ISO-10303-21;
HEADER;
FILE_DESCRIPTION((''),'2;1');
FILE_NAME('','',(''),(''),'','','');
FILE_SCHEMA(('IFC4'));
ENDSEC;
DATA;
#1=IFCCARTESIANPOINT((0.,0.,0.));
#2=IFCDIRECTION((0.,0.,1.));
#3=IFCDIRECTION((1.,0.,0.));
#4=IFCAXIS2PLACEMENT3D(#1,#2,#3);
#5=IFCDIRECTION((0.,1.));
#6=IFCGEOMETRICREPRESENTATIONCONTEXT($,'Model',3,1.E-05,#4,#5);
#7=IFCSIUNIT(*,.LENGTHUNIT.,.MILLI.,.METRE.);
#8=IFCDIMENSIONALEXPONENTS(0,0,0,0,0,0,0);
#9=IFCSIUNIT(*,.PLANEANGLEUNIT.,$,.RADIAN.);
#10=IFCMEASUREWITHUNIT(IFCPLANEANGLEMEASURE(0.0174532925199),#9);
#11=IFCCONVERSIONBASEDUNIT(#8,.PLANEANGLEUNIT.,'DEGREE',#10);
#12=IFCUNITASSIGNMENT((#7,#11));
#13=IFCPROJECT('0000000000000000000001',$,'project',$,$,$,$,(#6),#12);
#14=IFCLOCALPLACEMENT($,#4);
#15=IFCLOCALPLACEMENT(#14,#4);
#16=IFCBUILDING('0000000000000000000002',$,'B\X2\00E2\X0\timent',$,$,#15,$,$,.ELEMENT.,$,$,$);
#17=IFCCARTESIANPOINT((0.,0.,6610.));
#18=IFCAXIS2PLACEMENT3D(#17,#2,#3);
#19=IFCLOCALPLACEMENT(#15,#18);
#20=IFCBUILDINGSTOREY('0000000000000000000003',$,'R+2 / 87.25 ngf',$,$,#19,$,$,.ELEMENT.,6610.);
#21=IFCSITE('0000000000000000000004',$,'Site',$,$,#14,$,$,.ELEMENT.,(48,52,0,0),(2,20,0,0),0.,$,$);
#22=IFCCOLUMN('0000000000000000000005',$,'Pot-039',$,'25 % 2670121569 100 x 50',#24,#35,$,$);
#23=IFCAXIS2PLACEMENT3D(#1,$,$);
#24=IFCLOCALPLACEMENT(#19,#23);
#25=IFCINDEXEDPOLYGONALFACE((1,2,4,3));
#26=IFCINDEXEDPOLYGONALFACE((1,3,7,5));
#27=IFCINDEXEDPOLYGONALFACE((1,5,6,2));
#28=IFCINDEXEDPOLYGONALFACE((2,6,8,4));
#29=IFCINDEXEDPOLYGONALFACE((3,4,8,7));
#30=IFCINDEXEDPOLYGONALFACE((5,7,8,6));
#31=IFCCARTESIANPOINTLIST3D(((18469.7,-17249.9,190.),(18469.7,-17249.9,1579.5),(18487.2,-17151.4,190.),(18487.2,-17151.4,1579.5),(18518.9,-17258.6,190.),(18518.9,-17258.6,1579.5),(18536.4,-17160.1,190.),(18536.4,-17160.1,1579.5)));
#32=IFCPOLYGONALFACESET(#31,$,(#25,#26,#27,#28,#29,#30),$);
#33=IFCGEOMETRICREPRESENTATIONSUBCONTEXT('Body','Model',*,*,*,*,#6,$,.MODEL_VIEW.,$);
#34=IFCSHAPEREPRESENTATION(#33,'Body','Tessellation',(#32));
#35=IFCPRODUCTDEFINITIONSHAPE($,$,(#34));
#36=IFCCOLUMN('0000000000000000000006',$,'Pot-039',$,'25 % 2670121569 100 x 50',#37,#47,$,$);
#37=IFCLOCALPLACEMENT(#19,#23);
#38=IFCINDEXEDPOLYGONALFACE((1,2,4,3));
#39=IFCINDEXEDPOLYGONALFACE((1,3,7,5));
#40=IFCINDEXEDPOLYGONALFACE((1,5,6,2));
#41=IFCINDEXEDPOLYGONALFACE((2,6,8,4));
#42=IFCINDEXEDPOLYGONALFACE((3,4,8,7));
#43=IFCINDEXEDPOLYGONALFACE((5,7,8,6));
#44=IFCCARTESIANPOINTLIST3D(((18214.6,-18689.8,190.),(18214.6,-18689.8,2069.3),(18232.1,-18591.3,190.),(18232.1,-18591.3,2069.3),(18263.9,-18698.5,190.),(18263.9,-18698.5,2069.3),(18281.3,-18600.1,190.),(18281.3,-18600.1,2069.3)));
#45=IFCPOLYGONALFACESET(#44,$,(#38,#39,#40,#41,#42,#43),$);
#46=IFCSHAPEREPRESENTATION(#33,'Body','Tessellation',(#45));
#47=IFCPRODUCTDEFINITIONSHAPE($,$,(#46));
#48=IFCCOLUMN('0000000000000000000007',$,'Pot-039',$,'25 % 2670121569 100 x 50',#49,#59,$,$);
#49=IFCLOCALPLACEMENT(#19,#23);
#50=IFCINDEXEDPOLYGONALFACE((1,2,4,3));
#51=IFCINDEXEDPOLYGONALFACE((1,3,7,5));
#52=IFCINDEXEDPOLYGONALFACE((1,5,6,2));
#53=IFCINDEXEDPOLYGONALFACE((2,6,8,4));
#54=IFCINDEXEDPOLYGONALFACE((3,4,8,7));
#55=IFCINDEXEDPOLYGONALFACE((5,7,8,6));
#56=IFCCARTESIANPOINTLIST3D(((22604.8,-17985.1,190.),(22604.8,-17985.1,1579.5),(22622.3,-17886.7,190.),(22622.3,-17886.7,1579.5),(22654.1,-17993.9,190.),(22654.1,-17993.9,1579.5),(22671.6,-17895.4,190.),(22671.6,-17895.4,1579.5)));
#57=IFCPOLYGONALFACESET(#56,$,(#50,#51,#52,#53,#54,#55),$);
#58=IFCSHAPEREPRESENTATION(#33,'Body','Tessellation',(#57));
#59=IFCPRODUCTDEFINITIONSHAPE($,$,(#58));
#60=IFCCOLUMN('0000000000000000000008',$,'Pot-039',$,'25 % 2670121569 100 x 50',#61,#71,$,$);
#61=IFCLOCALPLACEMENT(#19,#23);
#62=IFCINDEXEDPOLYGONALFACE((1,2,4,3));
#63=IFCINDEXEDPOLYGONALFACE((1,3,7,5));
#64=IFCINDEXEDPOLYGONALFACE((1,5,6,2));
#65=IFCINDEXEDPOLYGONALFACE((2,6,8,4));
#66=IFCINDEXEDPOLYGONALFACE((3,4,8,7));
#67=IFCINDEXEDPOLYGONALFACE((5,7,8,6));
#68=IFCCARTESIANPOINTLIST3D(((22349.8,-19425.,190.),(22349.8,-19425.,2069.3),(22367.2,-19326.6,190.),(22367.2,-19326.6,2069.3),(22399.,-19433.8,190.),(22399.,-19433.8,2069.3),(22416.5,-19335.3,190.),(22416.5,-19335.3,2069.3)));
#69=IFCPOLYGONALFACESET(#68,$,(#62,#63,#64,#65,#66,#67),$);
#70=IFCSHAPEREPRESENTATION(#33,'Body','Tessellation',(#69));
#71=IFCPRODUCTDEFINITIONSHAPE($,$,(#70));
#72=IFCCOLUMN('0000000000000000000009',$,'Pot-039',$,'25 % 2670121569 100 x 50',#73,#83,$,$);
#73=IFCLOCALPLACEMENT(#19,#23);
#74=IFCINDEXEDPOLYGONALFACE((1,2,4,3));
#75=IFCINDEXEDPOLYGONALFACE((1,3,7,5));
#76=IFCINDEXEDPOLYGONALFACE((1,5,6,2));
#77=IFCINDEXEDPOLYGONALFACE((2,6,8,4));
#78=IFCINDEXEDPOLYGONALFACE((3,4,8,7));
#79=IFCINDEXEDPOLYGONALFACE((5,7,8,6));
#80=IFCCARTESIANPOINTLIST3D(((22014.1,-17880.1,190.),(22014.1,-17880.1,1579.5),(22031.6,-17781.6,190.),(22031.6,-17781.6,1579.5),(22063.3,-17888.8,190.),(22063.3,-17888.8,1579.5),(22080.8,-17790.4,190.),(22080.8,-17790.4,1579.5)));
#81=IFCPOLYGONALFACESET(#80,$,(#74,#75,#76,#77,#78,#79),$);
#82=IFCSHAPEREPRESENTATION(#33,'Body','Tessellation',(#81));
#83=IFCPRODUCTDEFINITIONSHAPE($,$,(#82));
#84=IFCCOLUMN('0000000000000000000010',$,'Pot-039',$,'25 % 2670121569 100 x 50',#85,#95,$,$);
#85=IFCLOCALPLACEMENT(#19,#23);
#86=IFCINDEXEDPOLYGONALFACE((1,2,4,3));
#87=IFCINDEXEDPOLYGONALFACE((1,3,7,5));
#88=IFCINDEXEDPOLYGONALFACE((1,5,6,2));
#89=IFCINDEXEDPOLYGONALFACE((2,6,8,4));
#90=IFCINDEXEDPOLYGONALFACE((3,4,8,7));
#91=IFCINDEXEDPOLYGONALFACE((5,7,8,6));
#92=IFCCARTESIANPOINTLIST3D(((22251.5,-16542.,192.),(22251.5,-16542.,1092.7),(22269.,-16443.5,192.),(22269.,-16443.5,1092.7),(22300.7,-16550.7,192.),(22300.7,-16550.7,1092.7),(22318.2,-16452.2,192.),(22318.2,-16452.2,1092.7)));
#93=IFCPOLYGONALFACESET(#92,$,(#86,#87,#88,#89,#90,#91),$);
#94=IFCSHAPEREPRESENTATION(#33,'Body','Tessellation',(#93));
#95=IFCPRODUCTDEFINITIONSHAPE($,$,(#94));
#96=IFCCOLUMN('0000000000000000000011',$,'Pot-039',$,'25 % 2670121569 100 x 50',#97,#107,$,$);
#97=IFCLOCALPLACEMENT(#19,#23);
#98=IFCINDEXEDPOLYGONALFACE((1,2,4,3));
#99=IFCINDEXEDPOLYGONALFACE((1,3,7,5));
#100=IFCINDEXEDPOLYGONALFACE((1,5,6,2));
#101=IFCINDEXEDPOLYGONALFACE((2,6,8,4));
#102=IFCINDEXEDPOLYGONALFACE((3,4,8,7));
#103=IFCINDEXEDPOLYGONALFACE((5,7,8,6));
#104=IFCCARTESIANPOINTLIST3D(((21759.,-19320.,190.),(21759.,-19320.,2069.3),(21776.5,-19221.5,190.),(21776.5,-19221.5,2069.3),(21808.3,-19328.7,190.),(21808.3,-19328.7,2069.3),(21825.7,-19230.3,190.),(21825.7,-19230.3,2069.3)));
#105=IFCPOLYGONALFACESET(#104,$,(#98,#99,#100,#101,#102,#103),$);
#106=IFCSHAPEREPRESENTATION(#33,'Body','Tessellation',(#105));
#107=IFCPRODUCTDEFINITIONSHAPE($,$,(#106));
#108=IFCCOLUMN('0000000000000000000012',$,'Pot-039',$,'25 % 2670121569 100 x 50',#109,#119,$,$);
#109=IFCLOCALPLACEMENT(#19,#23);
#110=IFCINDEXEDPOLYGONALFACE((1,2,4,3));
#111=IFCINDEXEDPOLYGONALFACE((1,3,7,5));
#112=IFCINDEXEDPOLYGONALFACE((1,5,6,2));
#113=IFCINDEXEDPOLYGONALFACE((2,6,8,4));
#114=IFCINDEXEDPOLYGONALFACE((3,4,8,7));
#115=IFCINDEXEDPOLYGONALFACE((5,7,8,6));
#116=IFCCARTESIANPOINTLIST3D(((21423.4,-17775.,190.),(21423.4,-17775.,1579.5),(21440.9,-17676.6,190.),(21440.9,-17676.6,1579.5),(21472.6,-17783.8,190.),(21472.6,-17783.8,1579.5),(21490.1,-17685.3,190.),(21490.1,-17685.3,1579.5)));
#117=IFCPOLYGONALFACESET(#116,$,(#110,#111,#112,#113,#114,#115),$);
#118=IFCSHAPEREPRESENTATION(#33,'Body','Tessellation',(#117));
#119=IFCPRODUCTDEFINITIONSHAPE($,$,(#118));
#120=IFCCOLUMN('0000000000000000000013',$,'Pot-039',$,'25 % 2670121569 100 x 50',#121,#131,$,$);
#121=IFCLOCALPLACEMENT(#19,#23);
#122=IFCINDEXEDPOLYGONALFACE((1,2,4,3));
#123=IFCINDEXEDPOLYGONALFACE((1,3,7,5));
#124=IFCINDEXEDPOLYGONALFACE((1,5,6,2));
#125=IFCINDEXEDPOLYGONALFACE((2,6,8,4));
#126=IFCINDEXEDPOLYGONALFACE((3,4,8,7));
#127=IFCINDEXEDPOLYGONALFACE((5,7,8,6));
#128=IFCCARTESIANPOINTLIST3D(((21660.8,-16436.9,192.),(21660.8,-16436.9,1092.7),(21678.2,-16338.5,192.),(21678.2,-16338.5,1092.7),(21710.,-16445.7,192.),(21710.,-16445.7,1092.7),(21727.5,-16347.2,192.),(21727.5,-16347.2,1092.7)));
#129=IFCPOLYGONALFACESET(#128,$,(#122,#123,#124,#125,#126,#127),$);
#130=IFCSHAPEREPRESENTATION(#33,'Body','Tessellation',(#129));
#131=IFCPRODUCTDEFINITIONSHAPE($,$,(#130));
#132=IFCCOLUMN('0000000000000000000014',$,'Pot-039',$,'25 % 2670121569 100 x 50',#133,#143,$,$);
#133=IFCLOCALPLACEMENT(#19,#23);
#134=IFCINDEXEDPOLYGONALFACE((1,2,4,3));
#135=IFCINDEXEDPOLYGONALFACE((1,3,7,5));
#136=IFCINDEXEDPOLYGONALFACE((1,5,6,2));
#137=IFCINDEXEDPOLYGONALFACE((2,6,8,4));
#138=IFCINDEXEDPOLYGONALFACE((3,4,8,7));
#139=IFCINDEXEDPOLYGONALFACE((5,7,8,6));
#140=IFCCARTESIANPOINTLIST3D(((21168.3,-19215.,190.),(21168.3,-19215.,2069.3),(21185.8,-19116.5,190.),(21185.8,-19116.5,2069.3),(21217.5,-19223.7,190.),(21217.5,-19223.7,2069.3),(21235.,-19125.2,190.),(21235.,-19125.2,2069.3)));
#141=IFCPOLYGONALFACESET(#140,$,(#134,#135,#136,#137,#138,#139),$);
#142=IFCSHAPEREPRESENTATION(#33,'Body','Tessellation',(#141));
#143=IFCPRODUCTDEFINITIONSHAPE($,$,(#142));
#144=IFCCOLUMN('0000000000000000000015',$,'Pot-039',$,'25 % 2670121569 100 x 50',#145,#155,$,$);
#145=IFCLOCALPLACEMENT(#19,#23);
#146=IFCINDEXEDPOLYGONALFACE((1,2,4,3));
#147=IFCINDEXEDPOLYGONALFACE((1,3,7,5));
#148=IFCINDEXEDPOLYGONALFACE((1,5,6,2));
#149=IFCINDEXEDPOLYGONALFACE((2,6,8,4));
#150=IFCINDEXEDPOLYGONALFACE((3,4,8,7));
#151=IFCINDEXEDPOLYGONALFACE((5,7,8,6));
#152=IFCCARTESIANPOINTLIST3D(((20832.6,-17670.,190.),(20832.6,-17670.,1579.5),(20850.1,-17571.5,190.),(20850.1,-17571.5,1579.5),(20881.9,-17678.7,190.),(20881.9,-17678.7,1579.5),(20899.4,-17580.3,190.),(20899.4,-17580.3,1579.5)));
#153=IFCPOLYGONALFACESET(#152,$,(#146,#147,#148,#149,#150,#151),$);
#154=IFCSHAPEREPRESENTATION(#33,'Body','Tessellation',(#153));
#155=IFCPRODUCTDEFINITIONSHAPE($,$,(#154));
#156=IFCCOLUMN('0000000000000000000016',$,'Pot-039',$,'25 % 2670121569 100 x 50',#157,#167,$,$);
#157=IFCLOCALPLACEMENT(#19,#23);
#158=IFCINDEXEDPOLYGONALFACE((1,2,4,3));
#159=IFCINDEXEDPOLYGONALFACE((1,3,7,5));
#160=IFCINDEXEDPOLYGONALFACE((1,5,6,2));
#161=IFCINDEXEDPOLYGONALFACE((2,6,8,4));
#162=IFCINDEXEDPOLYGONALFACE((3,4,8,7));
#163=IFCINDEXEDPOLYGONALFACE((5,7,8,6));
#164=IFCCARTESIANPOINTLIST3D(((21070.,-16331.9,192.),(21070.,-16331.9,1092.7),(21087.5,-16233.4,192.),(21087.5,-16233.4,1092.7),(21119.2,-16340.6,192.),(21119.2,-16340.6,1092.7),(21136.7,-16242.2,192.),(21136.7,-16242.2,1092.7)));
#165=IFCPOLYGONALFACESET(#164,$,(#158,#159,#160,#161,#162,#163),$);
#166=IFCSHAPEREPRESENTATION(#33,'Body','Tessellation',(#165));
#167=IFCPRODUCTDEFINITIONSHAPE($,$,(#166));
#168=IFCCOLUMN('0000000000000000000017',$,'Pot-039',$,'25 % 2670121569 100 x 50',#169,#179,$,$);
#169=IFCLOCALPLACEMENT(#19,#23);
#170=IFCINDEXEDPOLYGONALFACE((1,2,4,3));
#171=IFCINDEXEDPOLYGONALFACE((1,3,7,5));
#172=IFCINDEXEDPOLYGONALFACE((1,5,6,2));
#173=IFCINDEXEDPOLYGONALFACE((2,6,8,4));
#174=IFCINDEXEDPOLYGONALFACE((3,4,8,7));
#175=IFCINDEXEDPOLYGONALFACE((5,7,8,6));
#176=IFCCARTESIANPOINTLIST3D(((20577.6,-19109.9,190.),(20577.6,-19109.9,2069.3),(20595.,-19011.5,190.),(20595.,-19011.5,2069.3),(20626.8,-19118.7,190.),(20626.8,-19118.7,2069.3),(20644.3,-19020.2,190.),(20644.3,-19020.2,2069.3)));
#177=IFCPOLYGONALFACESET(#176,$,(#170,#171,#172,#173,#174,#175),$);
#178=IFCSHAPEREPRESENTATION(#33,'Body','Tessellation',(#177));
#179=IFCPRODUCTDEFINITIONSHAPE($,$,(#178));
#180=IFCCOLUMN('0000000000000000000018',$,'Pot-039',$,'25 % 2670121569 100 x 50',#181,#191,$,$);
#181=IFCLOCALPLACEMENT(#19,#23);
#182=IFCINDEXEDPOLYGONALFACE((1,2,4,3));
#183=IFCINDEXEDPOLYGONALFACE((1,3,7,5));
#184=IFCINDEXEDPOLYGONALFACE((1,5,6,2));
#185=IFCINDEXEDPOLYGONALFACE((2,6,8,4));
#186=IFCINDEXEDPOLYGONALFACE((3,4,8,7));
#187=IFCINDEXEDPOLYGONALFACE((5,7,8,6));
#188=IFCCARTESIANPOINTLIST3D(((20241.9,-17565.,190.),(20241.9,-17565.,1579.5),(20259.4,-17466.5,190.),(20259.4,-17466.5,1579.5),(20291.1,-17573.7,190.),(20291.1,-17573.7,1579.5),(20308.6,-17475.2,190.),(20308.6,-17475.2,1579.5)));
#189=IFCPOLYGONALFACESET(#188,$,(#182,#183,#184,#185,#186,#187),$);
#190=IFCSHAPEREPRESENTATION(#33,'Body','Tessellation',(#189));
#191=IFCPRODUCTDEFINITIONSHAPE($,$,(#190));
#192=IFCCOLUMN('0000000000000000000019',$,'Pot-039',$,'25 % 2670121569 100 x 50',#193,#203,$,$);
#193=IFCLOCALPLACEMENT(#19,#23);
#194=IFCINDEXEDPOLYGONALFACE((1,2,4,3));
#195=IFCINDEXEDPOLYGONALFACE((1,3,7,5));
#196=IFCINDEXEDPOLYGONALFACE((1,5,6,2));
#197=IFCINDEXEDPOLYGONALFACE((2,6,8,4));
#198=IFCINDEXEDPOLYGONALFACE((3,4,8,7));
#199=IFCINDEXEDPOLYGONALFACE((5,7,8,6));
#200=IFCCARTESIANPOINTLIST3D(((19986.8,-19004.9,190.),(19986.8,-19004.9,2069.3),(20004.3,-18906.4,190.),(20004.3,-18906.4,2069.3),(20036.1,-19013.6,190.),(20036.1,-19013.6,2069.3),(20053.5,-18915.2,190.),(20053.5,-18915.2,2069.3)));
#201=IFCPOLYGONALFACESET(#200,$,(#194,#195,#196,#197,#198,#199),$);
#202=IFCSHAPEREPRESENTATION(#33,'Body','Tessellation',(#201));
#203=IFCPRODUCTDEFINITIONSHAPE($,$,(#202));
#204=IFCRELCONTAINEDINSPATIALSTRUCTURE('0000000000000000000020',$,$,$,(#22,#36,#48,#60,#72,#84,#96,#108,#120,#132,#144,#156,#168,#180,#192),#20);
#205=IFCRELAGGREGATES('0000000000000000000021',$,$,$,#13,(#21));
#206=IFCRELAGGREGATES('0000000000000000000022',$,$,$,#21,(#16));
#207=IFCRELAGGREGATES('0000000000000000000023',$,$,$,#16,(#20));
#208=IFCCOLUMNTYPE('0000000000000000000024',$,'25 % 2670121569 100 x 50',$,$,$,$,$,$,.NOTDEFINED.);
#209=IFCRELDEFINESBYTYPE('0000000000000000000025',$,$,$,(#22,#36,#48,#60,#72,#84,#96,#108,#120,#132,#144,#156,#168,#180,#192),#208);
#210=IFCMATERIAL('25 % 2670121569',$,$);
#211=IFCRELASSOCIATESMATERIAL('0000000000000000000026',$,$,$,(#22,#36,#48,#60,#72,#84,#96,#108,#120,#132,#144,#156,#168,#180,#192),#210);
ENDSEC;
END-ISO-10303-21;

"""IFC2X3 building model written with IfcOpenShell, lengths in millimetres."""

from ifc_helpers import new_model, entity, si_unit, converted_unit, direction, frame, origin_with_axes, origin_2d_with_axis, place, context, subcontext, project, spatial, rectangle, extrude, material, type_object, element, save


model = new_model("IFC2X3")

# Units and contexts
model_context = context("Model", 3, precision=1e-05, world=origin_with_axes(), true_north=direction((0.0, 1.0)))
body_context = subcontext(model_context, "Body", "Model", "MODEL_VIEW")
ifc_project = project(units=[si_unit("LENGTHUNIT", "METRE", prefix="MILLI"), converted_unit("PLANEANGLEUNIT", "DEGREE", entity("IfcPlaneAngleMeasure", 0.0174532925199), si_unit("PLANEANGLEUNIT", "RADIAN"), dimensions=[0, 0, 0, 0, 0, 0, 0])], contexts=[model_context])

# Site, building, storey
site_placement = place(None, origin_with_axes())
site = spatial("IfcSite", under=ifc_project, at=site_placement, Name="Site", CompositionType="ELEMENT", RefLatitude=(48, 52, 0, 0), RefLongitude=(2, 20, 0, 0), RefElevation=0.0)
building_placement = place(site_placement, origin_with_axes())
building = spatial("IfcBuilding", under=site, at=building_placement, Name="Bâtiment", CompositionType="ELEMENT")
storey_placement = place(building_placement, frame((0.0, 0.0, 6610.0), z_axis=(0.0, 0.0, 1.0), x_axis=(1.0, 0.0, 0.0)))
storey = spatial("IfcBuildingStorey", under=building, at=storey_placement, Name="R+2 / 87.25 ngf", CompositionType="ELEMENT", Elevation=6610.0)

# Columns
ifc_material_1 = material(Name="25 % 2670121569")
column_type = type_object("IfcColumnType", Name="25 % 2670121569 100 x 50", PredefinedType="NOTDEFINED")
column_1_placement = place(storey_placement, frame((18503.1, -17205.0, 190.0), z_axis=(0.0, 0.0, 1.0), x_axis=(0.17478, 0.984607, 0.0)))
element("IfcColumn", 1, at=column_1_placement, inside=storey, type_object=column_type, material=ifc_material_1, Name="Pot-039", ObjectType="25 % 2670121569 100 x 50", context=body_context, shape_type="SweptSolid", body=[
    extrude(rectangle(XDim=100.0, YDim=50.0, at=origin_2d_with_axis()), origin_with_axes(), (0.0, 0.0, 1.0), 1389.5),
])
column_2_placement = place(storey_placement, frame((18248.0, -18644.9, 190.0), z_axis=(0.0, 0.0, 1.0), x_axis=(0.17478, 0.984607, 0.0)))
element("IfcColumn", 2, at=column_2_placement, inside=storey, type_object=column_type, material=ifc_material_1, Name="Pot-039", ObjectType="25 % 2670121569 100 x 50", context=body_context, shape_type="SweptSolid", body=[
    extrude(rectangle(XDim=100.0, YDim=50.0, at=origin_2d_with_axis()), origin_with_axes(), (0.0, 0.0, 1.0), 1879.3),
])
column_3_placement = place(storey_placement, frame((22638.2, -17940.3, 190.0), z_axis=(0.0, 0.0, 1.0), x_axis=(0.17478, 0.984607, 0.0)))
element("IfcColumn", 3, at=column_3_placement, inside=storey, type_object=column_type, material=ifc_material_1, Name="Pot-039", ObjectType="25 % 2670121569 100 x 50", context=body_context, shape_type="SweptSolid", body=[
    extrude(rectangle(XDim=100.0, YDim=50.0, at=origin_2d_with_axis()), origin_with_axes(), (0.0, 0.0, 1.0), 1389.5),
])
column_4_placement = place(storey_placement, frame((22383.1, -19380.2, 190.0), z_axis=(0.0, 0.0, 1.0), x_axis=(0.17478, 0.984607, 0.0)))
element("IfcColumn", 4, at=column_4_placement, inside=storey, type_object=column_type, material=ifc_material_1, Name="Pot-039", ObjectType="25 % 2670121569 100 x 50", context=body_context, shape_type="SweptSolid", body=[
    extrude(rectangle(XDim=100.0, YDim=50.0, at=origin_2d_with_axis()), origin_with_axes(), (0.0, 0.0, 1.0), 1879.3),
])
column_5_placement = place(storey_placement, frame((22047.5, -17835.2, 190.0), z_axis=(0.0, 0.0, 1.0), x_axis=(0.17478, 0.984607, 0.0)))
element("IfcColumn", 5, at=column_5_placement, inside=storey, type_object=column_type, material=ifc_material_1, Name="Pot-039", ObjectType="25 % 2670121569 100 x 50", context=body_context, shape_type="SweptSolid", body=[
    extrude(rectangle(XDim=100.0, YDim=50.0, at=origin_2d_with_axis()), origin_with_axes(), (0.0, 0.0, 1.0), 1389.5),
])
column_6_placement = place(storey_placement, frame((22284.8, -16497.1, 192.0), z_axis=(0.0, 0.0, 1.0), x_axis=(0.17478, 0.984607, 0.0)))
element("IfcColumn", 6, at=column_6_placement, inside=storey, type_object=column_type, material=ifc_material_1, Name="Pot-039", ObjectType="25 % 2670121569 100 x 50", context=body_context, shape_type="SweptSolid", body=[
    extrude(rectangle(XDim=100.0, YDim=50.0, at=origin_2d_with_axis()), origin_with_axes(), (0.0, 0.0, 1.0), 900.7),
])
column_7_placement = place(storey_placement, frame((21792.4, -19275.1, 190.0), z_axis=(0.0, 0.0, 1.0), x_axis=(0.17478, 0.984607, 0.0)))
element("IfcColumn", 7, at=column_7_placement, inside=storey, type_object=column_type, material=ifc_material_1, Name="Pot-039", ObjectType="25 % 2670121569 100 x 50", context=body_context, shape_type="SweptSolid", body=[
    extrude(rectangle(XDim=100.0, YDim=50.0, at=origin_2d_with_axis()), origin_with_axes(), (0.0, 0.0, 1.0), 1879.3),
])
column_8_placement = place(storey_placement, frame((21456.7, -17730.2, 190.0), z_axis=(0.0, 0.0, 1.0), x_axis=(0.17478, 0.984607, 0.0)))
element("IfcColumn", 8, at=column_8_placement, inside=storey, type_object=column_type, material=ifc_material_1, Name="Pot-039", ObjectType="25 % 2670121569 100 x 50", context=body_context, shape_type="SweptSolid", body=[
    extrude(rectangle(XDim=100.0, YDim=50.0, at=origin_2d_with_axis()), origin_with_axes(), (0.0, 0.0, 1.0), 1389.5),
])
column_9_placement = place(storey_placement, frame((21694.1, -16392.1, 192.0), z_axis=(0.0, 0.0, 1.0), x_axis=(0.17478, 0.984607, 0.0)))
element("IfcColumn", 9, at=column_9_placement, inside=storey, type_object=column_type, material=ifc_material_1, Name="Pot-039", ObjectType="25 % 2670121569 100 x 50", context=body_context, shape_type="SweptSolid", body=[
    extrude(rectangle(XDim=100.0, YDim=50.0, at=origin_2d_with_axis()), origin_with_axes(), (0.0, 0.0, 1.0), 900.7),
])
column_10_placement = place(storey_placement, frame((21201.7, -19170.1, 190.0), z_axis=(0.0, 0.0, 1.0), x_axis=(0.17478, 0.984607, 0.0)))
element("IfcColumn", 10, at=column_10_placement, inside=storey, type_object=column_type, material=ifc_material_1, Name="Pot-039", ObjectType="25 % 2670121569 100 x 50", context=body_context, shape_type="SweptSolid", body=[
    extrude(rectangle(XDim=100.0, YDim=50.0, at=origin_2d_with_axis()), origin_with_axes(), (0.0, 0.0, 1.0), 1879.3),
])
column_11_placement = place(storey_placement, frame((20866.0, -17625.1, 190.0), z_axis=(0.0, 0.0, 1.0), x_axis=(0.17478, 0.984607, 0.0)))
element("IfcColumn", 11, at=column_11_placement, inside=storey, type_object=column_type, material=ifc_material_1, Name="Pot-039", ObjectType="25 % 2670121569 100 x 50", context=body_context, shape_type="SweptSolid", body=[
    extrude(rectangle(XDim=100.0, YDim=50.0, at=origin_2d_with_axis()), origin_with_axes(), (0.0, 0.0, 1.0), 1389.5),
])
column_12_placement = place(storey_placement, frame((21103.4, -16287.0, 192.0), z_axis=(0.0, 0.0, 1.0), x_axis=(0.17478, 0.984607, 0.0)))
element("IfcColumn", 12, at=column_12_placement, inside=storey, type_object=column_type, material=ifc_material_1, Name="Pot-039", ObjectType="25 % 2670121569 100 x 50", context=body_context, shape_type="SweptSolid", body=[
    extrude(rectangle(XDim=100.0, YDim=50.0, at=origin_2d_with_axis()), origin_with_axes(), (0.0, 0.0, 1.0), 900.7),
])
column_13_placement = place(storey_placement, frame((20610.9, -19065.1, 190.0), z_axis=(0.0, 0.0, 1.0), x_axis=(0.17478, 0.984607, 0.0)))
element("IfcColumn", 13, at=column_13_placement, inside=storey, type_object=column_type, material=ifc_material_1, Name="Pot-039", ObjectType="25 % 2670121569 100 x 50", context=body_context, shape_type="SweptSolid", body=[
    extrude(rectangle(XDim=100.0, YDim=50.0, at=origin_2d_with_axis()), origin_with_axes(), (0.0, 0.0, 1.0), 1879.3),
])
column_14_placement = place(storey_placement, frame((20275.3, -17520.1, 190.0), z_axis=(0.0, 0.0, 1.0), x_axis=(0.17478, 0.984607, 0.0)))
element("IfcColumn", 14, at=column_14_placement, inside=storey, type_object=column_type, material=ifc_material_1, Name="Pot-039", ObjectType="25 % 2670121569 100 x 50", context=body_context, shape_type="SweptSolid", body=[
    extrude(rectangle(XDim=100.0, YDim=50.0, at=origin_2d_with_axis()), origin_with_axes(), (0.0, 0.0, 1.0), 1389.5),
])
column_15_placement = place(storey_placement, frame((20020.2, -18960.0, 190.0), z_axis=(0.0, 0.0, 1.0), x_axis=(0.17478, 0.984607, 0.0)))
element("IfcColumn", 15, at=column_15_placement, inside=storey, type_object=column_type, material=ifc_material_1, Name="Pot-039", ObjectType="25 % 2670121569 100 x 50", context=body_context, shape_type="SweptSolid", body=[
    extrude(rectangle(XDim=100.0, YDim=50.0, at=origin_2d_with_axis()), origin_with_axes(), (0.0, 0.0, 1.0), 1879.3),
])

save(model, "model.ifc")
